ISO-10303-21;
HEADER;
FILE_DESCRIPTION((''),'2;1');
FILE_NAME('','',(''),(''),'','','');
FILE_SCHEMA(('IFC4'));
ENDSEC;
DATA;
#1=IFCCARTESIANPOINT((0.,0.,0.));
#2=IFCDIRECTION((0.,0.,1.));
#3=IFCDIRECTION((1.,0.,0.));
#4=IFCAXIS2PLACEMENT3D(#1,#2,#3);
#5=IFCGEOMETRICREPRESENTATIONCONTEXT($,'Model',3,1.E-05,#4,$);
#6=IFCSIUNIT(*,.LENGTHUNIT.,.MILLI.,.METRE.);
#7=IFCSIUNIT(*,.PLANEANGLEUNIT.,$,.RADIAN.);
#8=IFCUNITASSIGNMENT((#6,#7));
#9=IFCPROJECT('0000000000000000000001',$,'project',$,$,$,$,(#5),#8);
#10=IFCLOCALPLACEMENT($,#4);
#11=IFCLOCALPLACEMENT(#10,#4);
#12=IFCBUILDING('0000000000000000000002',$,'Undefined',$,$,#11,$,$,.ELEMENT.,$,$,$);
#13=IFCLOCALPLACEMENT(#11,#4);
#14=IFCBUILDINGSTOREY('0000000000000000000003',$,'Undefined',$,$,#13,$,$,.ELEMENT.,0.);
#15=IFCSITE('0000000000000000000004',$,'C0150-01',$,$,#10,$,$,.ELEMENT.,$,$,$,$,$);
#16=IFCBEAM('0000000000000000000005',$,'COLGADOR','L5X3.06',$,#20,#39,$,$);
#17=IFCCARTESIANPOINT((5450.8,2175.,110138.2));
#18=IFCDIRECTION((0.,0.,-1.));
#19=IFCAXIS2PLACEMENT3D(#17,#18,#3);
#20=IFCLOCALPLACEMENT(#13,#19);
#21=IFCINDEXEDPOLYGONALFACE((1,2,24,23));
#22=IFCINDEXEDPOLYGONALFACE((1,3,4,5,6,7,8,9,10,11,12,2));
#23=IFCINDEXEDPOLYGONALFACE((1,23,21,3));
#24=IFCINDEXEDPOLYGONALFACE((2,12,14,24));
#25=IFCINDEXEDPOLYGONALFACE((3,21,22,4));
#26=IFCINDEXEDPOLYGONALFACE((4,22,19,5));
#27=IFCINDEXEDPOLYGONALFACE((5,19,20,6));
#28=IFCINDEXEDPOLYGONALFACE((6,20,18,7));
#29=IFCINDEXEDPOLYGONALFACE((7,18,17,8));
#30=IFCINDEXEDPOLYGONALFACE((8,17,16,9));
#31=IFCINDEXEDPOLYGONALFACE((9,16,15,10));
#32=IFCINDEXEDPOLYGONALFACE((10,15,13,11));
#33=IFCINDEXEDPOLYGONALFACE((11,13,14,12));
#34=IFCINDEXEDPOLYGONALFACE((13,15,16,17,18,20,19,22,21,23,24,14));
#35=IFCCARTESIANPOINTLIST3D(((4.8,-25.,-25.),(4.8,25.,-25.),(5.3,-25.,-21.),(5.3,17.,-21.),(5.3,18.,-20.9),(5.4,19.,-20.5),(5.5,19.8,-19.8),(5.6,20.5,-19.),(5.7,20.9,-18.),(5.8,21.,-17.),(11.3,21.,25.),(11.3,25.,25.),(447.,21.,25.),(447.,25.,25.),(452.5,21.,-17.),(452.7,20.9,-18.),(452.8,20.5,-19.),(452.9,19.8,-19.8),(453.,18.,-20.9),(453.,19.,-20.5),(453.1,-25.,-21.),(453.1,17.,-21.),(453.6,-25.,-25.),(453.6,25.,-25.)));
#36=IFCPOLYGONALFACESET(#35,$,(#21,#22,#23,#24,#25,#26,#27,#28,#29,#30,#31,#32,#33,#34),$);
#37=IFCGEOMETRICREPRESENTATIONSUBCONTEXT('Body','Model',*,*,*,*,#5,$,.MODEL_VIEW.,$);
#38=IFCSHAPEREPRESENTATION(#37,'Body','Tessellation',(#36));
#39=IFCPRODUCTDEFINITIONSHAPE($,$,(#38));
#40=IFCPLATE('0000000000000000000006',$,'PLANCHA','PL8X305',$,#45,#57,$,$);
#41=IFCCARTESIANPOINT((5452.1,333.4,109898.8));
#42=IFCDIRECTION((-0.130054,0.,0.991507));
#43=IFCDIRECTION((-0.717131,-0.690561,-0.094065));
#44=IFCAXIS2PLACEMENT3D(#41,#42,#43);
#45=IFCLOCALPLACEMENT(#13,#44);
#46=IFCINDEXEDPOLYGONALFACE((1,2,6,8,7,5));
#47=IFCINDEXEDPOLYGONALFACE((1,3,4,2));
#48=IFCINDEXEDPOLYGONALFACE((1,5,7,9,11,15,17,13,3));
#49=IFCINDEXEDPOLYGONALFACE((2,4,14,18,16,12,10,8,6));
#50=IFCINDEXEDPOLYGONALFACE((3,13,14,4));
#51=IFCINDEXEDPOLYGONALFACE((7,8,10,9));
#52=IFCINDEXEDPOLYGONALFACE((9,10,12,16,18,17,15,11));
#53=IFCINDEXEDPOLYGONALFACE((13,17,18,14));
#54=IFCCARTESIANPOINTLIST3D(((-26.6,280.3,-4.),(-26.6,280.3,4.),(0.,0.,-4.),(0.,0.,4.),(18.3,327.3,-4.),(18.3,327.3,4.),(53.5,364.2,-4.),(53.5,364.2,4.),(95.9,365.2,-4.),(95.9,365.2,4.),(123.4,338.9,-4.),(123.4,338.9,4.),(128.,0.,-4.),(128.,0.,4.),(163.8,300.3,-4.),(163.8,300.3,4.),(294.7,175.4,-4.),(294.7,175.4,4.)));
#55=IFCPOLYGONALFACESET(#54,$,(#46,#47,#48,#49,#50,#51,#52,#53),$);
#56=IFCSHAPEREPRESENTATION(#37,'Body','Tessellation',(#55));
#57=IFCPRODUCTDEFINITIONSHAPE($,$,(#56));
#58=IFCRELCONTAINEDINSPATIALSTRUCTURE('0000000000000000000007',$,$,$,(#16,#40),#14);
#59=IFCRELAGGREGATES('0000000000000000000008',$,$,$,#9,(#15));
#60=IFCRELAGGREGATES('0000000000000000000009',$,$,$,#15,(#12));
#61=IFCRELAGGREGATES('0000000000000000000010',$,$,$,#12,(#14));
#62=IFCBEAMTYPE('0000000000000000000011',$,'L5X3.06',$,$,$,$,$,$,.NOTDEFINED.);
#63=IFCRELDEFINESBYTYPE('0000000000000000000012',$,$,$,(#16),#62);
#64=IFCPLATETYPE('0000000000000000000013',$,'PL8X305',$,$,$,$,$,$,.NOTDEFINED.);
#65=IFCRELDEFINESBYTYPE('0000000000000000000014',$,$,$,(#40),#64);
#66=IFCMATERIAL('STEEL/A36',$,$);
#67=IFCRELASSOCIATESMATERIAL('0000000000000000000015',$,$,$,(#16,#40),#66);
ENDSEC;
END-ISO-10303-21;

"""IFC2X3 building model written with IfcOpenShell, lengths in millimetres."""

from ifc_helpers import new_model, si_unit, frame, origin_with_axes, origin_2d_with_axis, place, context, subcontext, project, spatial, polyline, l_section, outline, extrude, clip, halfspace, material, type_object, element, save


model = new_model("IFC2X3")

# Units and contexts
model_context = context("Model", 3, precision=1e-05, world=origin_with_axes())
body_context = subcontext(model_context, "Body", "Model", "MODEL_VIEW")
ifc_project = project(units=[si_unit("LENGTHUNIT", "METRE", prefix="MILLI"), si_unit("PLANEANGLEUNIT", "RADIAN")], contexts=[model_context])

# Site, building, storey
site_placement = place(None, origin_with_axes())
site = spatial("IfcSite", under=ifc_project, at=site_placement, Name="C0150-01", CompositionType="ELEMENT")
building_placement = place(site_placement, origin_with_axes())
building = spatial("IfcBuilding", under=site, at=building_placement, Name="Undefined", CompositionType="ELEMENT")
storey_placement = place(building_placement, origin_with_axes())
storey = spatial("IfcBuildingStorey", under=building, at=storey_placement, Name="Undefined", CompositionType="ELEMENT", Elevation=0.0)

# Beam
ifc_material_1 = material(Name="STEEL/A36")
beam_type_1 = type_object("IfcBeamType", Name="L5X3.06", PredefinedType="NOTDEFINED")
beam_placement = place(storey_placement, frame((5450.8, 2175.0, 110138.2), z_axis=(0.0, 0.0, -1.0), x_axis=(1.0, 0.0, 0.0)))
element("IfcBeam", 1, at=beam_placement, inside=storey, type_object=beam_type_1, material=ifc_material_1, Name="COLGADOR", Description="L5X3.06", context=body_context, shape_type="Clipping", body=[
    clip(clip(extrude(l_section(Depth=50.0, Width=50.0, Thickness=4.0, FilletRadius=4.0, at=origin_2d_with_axis()), frame((458.4, 0.0, 0.0), z_axis=(-1.0, 0.0, 0.0), x_axis=(0.0, -1.0, 0.0)), (0.0, 0.0, 1.0), 458.4), halfspace(frame((444.6, 0.0, 43.4), z_axis=(-0.991507, 0.0, -0.130054), x_axis=(0.130054, 0.0, -0.991507)), True)), halfspace(frame((13.8, 0.0, 43.4), z_axis=(0.991507, 0.0, -0.130054), x_axis=(0.0, 1.0, 0.0)), True)),
])

# Plate
plate_type_1 = type_object("IfcPlateType", Name="PL8X305", PredefinedType="NOTDEFINED")
plate_1_placement = place(storey_placement, frame((5452.1, 333.4, 109898.8), z_axis=(-0.130054, 0.0, 0.991507), x_axis=(-0.717131, -0.690561, -0.094065)))
element("IfcPlate", 2, at=plate_1_placement, inside=storey, type_object=plate_type_1, material=ifc_material_1, Name="PLANCHA", Description="PL8X305", context=body_context, shape_type="SweptSolid", body=[
    extrude(outline(polyline([(0.0, 0.0), (128.0, 0.0), (294.7, 175.4), (163.8, 300.3), (123.4, 338.9), (95.9, 365.2), (53.5, 364.2), (18.3, 327.3), (-26.6, 280.3), (0.0, 0.0)])), frame((0.0, 0.0, -4.0), z_axis=(0.0, 0.0, 1.0), x_axis=(1.0, 0.0, 0.0)), (0.0, 0.0, 1.0), 8.0),
])

save(model, "model.ifc")
